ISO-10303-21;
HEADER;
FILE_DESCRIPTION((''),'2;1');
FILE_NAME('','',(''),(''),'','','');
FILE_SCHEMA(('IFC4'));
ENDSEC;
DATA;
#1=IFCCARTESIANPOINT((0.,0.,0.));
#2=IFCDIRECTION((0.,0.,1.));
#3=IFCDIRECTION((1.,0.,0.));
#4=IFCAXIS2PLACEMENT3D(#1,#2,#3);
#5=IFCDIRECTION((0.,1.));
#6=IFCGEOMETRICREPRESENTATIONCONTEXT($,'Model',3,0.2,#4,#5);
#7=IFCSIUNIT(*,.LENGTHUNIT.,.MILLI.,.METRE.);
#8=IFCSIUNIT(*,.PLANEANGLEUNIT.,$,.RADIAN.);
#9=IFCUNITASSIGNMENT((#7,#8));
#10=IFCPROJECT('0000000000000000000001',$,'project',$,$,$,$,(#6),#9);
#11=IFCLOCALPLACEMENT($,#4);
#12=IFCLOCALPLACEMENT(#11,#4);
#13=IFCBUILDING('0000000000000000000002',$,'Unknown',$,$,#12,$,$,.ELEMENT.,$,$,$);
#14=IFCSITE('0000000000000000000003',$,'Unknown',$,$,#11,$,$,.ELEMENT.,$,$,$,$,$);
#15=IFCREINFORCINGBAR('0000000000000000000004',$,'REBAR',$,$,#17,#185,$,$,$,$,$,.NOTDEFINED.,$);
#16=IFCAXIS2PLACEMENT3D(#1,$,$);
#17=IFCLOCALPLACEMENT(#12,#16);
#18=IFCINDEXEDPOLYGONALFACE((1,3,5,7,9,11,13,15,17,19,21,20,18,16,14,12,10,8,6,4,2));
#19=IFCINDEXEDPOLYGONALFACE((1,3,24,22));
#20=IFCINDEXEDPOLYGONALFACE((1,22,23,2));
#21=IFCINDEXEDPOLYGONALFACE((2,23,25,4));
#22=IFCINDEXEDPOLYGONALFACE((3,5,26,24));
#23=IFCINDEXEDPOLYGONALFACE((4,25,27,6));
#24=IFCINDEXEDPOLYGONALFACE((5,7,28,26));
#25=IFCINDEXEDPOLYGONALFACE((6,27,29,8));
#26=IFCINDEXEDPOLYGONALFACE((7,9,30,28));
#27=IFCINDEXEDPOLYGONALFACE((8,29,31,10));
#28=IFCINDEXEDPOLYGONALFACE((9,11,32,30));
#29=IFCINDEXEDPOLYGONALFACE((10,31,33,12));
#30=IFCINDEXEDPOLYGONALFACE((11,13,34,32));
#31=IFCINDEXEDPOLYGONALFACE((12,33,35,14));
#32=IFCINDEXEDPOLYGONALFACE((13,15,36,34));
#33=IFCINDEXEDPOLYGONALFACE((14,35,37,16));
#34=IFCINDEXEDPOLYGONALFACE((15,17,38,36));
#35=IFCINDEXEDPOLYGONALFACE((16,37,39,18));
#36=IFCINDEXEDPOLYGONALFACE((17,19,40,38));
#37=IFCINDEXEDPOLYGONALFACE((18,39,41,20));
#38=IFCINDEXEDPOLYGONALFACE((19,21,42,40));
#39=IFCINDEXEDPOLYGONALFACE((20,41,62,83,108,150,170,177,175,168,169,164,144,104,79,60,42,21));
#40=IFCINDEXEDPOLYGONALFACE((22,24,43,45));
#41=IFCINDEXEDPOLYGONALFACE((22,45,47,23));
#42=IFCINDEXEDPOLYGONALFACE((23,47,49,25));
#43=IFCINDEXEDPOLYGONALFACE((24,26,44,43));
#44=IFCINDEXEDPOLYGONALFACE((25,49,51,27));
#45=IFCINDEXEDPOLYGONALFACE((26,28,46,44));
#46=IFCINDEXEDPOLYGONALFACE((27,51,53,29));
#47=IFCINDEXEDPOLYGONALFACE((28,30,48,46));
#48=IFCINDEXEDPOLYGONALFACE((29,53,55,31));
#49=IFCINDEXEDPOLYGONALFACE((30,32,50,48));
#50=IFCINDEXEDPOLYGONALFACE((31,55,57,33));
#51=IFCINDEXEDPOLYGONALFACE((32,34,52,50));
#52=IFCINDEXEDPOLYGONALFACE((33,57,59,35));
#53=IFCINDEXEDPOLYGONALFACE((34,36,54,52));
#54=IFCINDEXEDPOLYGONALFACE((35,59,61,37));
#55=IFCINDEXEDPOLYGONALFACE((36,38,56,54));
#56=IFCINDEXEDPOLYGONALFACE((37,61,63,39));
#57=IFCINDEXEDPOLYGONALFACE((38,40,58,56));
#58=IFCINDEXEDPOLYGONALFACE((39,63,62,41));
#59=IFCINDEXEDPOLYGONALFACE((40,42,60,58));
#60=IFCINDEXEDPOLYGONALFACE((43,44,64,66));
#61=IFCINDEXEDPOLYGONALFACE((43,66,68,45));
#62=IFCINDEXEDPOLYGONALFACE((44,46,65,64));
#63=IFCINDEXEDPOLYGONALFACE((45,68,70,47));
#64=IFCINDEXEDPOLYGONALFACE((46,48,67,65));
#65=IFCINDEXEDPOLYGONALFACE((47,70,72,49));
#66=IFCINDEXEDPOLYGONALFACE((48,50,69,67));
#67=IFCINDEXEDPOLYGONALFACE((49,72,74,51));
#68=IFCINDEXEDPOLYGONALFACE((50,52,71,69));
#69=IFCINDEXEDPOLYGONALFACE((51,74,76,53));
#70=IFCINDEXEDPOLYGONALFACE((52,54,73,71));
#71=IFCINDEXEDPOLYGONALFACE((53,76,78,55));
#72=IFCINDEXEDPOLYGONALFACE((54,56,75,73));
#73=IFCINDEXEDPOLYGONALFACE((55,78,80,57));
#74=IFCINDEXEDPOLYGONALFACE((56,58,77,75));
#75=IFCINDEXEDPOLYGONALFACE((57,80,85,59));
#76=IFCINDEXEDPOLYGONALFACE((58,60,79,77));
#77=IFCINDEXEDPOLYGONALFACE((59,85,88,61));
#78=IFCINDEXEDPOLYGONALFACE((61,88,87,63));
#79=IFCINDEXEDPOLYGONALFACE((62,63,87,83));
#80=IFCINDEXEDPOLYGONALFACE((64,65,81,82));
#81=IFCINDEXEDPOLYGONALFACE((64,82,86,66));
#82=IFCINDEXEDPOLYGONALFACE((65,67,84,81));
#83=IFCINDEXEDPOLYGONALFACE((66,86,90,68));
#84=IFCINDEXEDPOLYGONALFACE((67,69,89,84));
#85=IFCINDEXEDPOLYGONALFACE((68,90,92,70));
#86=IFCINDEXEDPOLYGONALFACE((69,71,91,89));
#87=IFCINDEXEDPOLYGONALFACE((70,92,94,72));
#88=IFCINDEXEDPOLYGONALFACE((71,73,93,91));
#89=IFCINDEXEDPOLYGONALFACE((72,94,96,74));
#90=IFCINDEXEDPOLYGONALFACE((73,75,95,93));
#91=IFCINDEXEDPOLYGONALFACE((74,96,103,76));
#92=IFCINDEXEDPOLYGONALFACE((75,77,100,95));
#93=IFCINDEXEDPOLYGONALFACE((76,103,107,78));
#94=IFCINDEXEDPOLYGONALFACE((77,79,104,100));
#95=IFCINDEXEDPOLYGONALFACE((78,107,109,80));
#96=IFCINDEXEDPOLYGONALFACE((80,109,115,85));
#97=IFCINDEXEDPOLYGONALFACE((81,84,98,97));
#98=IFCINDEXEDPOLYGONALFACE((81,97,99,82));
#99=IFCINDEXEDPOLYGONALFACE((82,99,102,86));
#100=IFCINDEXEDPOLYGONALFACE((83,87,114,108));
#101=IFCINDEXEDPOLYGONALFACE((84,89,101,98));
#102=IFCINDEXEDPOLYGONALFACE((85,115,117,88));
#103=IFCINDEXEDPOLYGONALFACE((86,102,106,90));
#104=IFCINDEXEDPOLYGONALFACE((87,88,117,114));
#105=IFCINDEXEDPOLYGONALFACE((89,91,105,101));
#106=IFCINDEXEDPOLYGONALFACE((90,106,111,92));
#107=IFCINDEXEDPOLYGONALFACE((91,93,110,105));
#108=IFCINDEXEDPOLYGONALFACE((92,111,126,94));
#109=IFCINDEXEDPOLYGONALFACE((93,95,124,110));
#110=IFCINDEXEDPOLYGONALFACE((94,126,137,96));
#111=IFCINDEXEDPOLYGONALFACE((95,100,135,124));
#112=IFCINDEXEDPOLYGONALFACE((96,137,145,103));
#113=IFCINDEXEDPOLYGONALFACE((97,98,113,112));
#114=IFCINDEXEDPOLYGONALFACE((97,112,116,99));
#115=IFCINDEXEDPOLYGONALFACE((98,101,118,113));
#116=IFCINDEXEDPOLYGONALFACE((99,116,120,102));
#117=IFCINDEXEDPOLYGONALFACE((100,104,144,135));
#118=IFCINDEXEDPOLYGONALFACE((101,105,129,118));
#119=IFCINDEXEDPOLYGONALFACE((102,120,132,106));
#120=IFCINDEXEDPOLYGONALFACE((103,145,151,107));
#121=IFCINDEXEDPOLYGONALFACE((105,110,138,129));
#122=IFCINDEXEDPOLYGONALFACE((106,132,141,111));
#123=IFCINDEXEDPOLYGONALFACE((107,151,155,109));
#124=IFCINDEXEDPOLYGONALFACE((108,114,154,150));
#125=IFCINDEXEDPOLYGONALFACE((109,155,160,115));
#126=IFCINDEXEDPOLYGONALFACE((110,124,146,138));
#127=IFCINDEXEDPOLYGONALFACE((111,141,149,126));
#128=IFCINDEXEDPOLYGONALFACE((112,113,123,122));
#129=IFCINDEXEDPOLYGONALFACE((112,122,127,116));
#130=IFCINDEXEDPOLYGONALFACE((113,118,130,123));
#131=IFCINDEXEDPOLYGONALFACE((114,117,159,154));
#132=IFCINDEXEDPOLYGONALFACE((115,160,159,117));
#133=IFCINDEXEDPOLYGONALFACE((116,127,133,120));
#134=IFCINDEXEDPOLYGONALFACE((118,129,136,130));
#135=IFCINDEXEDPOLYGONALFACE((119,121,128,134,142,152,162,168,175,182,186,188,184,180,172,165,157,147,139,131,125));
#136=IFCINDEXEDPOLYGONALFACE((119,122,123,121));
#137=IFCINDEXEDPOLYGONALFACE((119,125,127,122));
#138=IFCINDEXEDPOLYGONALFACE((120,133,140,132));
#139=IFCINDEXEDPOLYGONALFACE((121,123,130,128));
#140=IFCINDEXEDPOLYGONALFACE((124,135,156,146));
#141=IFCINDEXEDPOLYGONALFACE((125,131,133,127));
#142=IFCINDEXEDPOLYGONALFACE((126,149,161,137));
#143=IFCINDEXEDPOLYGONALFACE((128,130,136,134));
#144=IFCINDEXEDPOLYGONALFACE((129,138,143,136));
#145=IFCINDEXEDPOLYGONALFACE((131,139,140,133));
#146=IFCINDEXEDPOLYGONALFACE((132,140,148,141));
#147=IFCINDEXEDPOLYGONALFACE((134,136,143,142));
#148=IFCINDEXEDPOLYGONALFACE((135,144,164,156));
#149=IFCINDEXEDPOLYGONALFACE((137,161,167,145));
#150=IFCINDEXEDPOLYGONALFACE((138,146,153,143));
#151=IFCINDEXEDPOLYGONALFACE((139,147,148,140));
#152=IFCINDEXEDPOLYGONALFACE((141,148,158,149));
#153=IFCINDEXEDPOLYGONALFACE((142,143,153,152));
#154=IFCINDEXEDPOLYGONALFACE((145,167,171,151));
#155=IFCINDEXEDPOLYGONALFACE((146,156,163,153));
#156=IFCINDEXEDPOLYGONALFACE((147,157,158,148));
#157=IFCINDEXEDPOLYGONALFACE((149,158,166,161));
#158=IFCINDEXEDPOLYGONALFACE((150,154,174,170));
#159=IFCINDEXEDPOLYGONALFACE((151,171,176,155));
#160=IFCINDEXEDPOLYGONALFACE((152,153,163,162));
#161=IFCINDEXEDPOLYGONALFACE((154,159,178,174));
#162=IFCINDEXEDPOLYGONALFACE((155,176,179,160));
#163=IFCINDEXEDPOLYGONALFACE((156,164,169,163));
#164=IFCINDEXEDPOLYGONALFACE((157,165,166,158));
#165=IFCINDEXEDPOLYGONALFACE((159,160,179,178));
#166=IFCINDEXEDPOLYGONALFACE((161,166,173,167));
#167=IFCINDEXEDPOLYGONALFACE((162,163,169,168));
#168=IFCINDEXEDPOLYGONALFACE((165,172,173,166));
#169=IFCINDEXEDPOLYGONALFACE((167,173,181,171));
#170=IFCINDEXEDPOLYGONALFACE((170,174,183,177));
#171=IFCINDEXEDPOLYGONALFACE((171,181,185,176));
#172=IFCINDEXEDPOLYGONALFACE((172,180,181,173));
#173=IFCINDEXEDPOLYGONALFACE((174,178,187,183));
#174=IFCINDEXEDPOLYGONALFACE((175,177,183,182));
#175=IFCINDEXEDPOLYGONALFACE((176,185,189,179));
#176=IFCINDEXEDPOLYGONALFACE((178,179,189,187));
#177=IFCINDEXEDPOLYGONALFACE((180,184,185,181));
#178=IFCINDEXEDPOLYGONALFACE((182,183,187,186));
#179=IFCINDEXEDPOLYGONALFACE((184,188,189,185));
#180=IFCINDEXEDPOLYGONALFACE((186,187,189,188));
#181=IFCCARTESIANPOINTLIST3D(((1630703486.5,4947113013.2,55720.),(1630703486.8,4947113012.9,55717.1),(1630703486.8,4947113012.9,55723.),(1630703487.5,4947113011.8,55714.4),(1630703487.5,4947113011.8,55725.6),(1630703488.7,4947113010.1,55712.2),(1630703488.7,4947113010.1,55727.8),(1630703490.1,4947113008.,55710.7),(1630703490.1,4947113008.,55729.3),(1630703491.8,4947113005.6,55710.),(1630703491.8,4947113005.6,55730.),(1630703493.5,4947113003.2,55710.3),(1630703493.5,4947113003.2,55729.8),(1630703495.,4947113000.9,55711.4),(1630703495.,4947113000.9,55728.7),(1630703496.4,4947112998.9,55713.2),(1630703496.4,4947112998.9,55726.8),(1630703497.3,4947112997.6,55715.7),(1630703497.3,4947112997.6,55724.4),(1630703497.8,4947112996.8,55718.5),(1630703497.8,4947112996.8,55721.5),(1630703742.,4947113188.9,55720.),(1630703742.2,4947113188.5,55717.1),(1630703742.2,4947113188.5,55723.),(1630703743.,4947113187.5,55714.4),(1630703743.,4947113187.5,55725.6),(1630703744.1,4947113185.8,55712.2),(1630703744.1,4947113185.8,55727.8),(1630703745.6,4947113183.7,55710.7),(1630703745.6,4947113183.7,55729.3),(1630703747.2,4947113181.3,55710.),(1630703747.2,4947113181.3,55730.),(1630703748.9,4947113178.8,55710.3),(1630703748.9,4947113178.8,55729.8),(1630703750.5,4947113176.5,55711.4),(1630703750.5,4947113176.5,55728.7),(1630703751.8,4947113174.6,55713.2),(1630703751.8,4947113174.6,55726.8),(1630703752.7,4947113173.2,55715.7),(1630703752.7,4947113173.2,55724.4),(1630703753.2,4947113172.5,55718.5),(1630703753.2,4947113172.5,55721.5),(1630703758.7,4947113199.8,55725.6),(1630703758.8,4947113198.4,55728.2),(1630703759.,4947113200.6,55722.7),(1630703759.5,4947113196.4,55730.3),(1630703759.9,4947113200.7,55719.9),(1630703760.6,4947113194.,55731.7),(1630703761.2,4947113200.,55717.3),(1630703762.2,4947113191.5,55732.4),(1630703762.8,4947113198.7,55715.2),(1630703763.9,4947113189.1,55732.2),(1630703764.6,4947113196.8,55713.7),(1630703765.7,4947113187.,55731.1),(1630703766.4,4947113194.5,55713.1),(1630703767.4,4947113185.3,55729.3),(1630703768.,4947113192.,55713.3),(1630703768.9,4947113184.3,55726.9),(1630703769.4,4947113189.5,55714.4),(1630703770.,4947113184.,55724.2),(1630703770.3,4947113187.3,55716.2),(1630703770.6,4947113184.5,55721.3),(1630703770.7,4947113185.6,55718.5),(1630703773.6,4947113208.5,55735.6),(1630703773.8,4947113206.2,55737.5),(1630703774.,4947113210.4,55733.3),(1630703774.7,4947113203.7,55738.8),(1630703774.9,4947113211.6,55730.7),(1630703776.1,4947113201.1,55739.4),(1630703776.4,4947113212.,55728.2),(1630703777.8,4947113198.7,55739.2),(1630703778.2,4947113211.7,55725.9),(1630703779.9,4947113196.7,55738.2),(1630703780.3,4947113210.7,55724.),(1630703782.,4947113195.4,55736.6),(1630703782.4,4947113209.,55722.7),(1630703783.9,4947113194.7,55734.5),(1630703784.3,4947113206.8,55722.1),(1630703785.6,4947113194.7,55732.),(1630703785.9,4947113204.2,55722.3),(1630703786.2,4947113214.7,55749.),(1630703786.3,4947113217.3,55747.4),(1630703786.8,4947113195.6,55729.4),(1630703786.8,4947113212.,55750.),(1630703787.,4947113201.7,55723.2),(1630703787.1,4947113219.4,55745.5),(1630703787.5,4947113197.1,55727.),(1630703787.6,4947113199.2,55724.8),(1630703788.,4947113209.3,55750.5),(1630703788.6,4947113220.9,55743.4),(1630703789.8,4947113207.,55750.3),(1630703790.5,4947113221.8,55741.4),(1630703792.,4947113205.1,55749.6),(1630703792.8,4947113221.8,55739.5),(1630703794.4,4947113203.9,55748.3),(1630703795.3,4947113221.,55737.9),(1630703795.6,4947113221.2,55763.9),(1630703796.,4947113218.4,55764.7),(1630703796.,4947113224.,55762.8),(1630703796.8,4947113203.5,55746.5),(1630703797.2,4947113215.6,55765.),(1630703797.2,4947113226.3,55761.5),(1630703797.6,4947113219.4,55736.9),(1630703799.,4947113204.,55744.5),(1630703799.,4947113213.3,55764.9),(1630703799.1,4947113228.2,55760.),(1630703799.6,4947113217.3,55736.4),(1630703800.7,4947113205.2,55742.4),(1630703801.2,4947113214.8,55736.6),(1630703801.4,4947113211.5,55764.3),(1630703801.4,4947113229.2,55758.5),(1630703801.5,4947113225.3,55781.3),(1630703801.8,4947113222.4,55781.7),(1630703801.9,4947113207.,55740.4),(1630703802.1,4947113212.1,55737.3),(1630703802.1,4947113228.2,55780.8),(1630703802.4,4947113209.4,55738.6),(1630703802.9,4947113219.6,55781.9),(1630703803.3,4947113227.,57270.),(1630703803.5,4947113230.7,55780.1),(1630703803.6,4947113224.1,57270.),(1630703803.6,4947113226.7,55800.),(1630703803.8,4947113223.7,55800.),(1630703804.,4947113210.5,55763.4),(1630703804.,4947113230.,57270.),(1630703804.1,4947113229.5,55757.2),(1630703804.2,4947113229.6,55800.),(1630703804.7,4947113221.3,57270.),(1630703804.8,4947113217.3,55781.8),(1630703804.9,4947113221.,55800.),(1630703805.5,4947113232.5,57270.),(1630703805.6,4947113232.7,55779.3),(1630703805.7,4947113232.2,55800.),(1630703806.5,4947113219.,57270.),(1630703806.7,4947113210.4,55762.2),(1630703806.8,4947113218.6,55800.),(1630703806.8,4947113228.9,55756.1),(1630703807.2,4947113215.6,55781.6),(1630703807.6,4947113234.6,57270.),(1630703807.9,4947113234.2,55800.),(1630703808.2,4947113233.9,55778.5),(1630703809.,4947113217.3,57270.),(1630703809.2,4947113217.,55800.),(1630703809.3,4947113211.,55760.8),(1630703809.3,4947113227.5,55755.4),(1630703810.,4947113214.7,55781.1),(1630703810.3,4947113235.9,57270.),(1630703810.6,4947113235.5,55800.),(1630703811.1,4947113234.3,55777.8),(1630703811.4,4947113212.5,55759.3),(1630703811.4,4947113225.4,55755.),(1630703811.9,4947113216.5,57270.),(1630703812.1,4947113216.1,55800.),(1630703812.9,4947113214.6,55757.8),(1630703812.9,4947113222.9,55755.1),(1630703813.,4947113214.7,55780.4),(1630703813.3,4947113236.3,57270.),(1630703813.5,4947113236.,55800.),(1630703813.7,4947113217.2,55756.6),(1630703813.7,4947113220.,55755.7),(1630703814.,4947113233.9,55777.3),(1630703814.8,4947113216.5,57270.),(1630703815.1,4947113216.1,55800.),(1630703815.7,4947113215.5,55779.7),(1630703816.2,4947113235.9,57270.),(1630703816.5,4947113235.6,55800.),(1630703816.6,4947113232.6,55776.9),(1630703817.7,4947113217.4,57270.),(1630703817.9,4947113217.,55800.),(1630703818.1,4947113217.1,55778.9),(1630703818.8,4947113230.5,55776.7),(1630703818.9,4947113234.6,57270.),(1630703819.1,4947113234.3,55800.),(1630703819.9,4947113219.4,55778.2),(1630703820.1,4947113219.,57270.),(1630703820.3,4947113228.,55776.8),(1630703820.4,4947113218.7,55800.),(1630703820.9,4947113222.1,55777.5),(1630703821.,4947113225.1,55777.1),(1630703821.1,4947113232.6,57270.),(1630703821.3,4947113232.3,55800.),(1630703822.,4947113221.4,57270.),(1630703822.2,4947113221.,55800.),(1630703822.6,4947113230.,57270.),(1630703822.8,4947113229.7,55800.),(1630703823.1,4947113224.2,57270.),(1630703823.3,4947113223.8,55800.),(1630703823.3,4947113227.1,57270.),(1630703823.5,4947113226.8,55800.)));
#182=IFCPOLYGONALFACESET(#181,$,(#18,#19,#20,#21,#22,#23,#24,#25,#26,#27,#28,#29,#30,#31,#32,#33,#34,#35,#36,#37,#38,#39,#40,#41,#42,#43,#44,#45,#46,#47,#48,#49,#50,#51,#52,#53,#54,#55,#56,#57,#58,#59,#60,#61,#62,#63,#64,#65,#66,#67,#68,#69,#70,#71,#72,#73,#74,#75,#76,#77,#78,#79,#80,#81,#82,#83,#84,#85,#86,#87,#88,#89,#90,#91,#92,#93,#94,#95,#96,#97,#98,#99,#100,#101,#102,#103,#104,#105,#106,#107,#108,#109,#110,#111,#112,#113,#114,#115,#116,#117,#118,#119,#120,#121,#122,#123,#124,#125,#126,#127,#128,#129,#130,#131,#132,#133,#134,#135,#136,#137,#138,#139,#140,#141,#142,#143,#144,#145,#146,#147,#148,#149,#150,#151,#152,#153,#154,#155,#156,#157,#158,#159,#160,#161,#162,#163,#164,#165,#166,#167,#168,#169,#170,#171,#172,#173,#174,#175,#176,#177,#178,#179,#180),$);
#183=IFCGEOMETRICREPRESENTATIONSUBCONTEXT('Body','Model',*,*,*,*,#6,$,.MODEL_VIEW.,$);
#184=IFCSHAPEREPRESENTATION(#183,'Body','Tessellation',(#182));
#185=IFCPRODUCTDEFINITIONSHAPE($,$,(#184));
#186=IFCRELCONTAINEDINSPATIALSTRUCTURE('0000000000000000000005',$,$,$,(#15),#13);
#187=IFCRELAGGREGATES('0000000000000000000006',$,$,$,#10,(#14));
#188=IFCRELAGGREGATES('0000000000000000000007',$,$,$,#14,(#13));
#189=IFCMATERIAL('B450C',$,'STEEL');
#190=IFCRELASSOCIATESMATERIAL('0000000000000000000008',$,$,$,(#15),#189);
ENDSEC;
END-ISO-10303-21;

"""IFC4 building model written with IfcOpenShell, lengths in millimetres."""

from ifc_helpers import new_model, entity, si_unit, direction, frame, origin_with_axes, place, context, subcontext, project, spatial, material, element, save


model = new_model("IFC4")

# Units and contexts
model_context = context("Model", 3, precision=0.2, world=origin_with_axes(), true_north=direction((0.0, 1.0)))
body_context = subcontext(model_context, "Body", "Model", "MODEL_VIEW")
ifc_project = project(units=[si_unit("LENGTHUNIT", "METRE", prefix="MILLI"), si_unit("PLANEANGLEUNIT", "RADIAN")], contexts=[model_context])

# Site, building
site_placement = place(None, origin_with_axes())
site = spatial("IfcSite", under=ifc_project, at=site_placement, Name="Unknown", CompositionType="ELEMENT")
building_placement = place(site_placement, origin_with_axes())
building = spatial("IfcBuilding", under=site, at=building_placement, Name="Unknown", CompositionType="ELEMENT")

# Reinforcing bar
ifc_material = material(Name="B450C", Category="STEEL")
reinforcing_bar_1_placement = place(building_placement, frame((1630703826.4, 4947113295.5, 55670.0), z_axis=(0.566651, -0.823958, 0.0), x_axis=(0.0, 0.0, 1.0)))
element("IfcReinforcingBar", 1, at=reinforcing_bar_1_placement, inside=building, material=ifc_material, Name="REBAR", PredefinedType="NOTDEFINED", context=body_context, shape_type="AdvancedSweptSolid", body=[
    entity("IfcSweptDiskSolid", entity("IfcIndexedPolyCurve", entity("IfcCartesianPointList3D", [[50.0, 440.0, 50.0], [50.0, 130.0, 50.0], [73.4, 73.4, 50.0], [130.0, 50.0, 50.0], [1600.0, 50.0, 49.5]]), [entity("IfcLineIndex", [1, 2]), entity("IfcArcIndex", [2, 3, 4]), entity("IfcLineIndex", [4, 5])]), 10.0),
])

save(model, "model.ifc")
